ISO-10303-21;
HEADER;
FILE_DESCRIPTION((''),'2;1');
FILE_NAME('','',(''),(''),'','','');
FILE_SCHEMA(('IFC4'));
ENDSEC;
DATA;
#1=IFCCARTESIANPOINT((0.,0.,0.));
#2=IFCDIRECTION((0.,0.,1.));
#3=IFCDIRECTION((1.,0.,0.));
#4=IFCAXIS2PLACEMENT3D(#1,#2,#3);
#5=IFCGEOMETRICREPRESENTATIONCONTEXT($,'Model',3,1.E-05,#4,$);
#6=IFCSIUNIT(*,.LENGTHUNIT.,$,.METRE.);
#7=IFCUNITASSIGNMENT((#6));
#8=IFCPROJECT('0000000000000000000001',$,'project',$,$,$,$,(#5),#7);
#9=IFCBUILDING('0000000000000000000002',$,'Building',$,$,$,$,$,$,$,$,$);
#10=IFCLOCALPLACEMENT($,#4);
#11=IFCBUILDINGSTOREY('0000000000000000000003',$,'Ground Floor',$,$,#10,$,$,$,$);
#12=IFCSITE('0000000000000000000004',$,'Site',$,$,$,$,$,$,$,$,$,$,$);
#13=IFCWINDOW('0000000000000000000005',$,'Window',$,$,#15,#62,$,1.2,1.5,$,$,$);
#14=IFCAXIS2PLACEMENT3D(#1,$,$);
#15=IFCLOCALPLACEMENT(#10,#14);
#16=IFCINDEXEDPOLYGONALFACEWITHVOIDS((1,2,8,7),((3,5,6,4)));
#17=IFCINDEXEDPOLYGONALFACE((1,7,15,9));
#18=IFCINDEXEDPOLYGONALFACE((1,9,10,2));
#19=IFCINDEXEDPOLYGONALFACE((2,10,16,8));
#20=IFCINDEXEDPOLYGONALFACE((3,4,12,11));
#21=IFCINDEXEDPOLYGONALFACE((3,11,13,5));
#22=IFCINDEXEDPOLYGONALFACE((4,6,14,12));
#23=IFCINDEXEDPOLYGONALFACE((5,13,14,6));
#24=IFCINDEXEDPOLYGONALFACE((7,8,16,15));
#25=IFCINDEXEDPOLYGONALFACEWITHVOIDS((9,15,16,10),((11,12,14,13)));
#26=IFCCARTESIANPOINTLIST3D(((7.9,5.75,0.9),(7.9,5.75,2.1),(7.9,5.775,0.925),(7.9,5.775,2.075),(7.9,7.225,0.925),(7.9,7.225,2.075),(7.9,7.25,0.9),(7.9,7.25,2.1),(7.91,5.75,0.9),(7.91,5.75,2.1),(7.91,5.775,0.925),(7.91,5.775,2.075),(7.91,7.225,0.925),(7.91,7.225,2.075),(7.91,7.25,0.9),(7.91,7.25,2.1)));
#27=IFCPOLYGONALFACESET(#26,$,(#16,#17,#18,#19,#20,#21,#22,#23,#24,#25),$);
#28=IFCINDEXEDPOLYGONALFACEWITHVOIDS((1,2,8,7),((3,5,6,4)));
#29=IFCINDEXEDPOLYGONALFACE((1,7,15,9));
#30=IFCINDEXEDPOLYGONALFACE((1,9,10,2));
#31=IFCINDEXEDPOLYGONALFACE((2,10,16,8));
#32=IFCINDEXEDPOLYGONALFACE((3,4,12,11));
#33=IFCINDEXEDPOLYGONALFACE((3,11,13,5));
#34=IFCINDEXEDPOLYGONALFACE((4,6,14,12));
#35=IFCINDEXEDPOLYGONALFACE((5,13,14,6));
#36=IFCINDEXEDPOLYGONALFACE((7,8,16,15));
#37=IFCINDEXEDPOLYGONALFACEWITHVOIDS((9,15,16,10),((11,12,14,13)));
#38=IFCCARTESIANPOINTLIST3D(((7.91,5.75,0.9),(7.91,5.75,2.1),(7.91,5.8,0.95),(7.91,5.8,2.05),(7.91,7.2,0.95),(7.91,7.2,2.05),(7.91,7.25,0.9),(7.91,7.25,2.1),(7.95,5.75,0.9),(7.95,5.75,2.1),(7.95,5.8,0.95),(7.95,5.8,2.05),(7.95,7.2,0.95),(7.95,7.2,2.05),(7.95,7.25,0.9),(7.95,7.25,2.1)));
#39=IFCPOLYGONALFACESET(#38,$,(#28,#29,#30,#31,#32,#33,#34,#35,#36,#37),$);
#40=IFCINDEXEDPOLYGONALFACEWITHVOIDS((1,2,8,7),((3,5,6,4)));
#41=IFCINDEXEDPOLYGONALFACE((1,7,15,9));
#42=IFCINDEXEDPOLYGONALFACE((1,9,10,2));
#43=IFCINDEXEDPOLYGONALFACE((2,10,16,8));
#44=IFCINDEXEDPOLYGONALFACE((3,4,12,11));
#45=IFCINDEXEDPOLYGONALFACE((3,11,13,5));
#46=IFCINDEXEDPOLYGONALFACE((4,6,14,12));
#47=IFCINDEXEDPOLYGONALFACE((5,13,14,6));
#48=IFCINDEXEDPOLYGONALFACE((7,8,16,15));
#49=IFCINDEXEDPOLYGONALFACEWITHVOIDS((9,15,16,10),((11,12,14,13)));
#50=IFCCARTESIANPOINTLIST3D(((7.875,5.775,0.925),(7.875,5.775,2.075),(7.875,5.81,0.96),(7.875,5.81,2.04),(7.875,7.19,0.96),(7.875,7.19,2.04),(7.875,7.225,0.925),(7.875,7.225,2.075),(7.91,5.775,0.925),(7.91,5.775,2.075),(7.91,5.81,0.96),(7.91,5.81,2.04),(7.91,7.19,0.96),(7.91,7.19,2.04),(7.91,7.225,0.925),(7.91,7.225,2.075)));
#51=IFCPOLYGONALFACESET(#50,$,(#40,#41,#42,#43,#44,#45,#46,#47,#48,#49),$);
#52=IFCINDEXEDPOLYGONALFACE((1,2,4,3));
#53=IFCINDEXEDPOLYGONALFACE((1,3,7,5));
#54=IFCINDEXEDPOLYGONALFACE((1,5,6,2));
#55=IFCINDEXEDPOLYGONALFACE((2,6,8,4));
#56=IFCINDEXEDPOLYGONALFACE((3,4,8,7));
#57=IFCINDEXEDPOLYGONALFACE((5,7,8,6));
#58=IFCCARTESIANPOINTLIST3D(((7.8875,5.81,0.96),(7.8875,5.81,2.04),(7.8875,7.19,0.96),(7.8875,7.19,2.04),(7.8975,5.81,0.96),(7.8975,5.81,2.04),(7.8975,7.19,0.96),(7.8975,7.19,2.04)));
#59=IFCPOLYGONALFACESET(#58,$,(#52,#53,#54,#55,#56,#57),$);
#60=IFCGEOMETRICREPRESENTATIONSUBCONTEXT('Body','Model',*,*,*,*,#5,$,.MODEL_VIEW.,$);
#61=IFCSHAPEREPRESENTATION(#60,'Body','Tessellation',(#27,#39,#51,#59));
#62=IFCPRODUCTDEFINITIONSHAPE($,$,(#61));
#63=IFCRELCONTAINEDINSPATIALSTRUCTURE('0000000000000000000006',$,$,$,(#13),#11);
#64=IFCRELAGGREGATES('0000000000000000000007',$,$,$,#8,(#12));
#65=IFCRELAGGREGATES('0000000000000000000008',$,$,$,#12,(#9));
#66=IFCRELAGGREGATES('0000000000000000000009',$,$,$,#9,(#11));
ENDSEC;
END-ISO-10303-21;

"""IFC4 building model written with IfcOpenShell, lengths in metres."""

from ifc_helpers import new_model, si_unit, frame, origin_with_axes, place, context, subcontext, project, spatial, line, indexed_curve, outline, extrude, element, save


model = new_model("IFC4")

# Units and contexts
model_context = context("Model", 3, precision=1e-05, world=origin_with_axes())
body_context = subcontext(model_context, "Body", "Model", "MODEL_VIEW")
ifc_project = project(units=[si_unit("LENGTHUNIT", "METRE")], contexts=[model_context])

# Site, building, storey
site = spatial("IfcSite", under=ifc_project, Name="Site")
building = spatial("IfcBuilding", under=site, Name="Building")
storey_placement = place(None, origin_with_axes())
storey = spatial("IfcBuildingStorey", under=building, at=storey_placement, Name="Ground Floor")

# Window
for number, where, z_axis, x_axis, name in (
    (1, (8.0, 5.75, 0.9), (0.0, 0.0, 1.0), (0.0, 1.0, 0.0), "Window"),
):
    element("IfcWindow", number, at=place(storey_placement, frame(where, z_axis=z_axis, x_axis=x_axis)), inside=storey, Name=name, OverallHeight=1.2, OverallWidth=1.5, context=body_context, shape_type="SweptSolid", body=[
        extrude(outline(indexed_curve([(0.0, 0.0), (1.5, 0.0), (1.5, 1.2), (0.0, 1.2)], segments=[line(1, 2, 3, 4, 1)]), holes=[indexed_curve([(0.025, 0.025), (1.475, 0.025), (1.475, 1.175), (0.025, 1.175)], segments=[line(1, 2, 3, 4, 1)])]), frame((0.0, 0.09, 0.0), z_axis=(0.0, -1.0, 0.0), x_axis=(1.0, 0.0, 0.0)), (0.0, 0.0, -1.0), 0.01),
        extrude(outline(indexed_curve([(0.0, 0.0), (1.5, 0.0), (1.5, 1.2), (0.0, 1.2)], segments=[line(1, 2, 3, 4, 1)]), holes=[indexed_curve([(0.05, 0.05), (1.45, 0.05), (1.45, 1.15), (0.05, 1.15)], segments=[line(1, 2, 3, 4, 1)])]), frame((0.0, 0.05, 0.0), z_axis=(0.0, -1.0, 0.0), x_axis=(1.0, 0.0, 0.0)), (0.0, 0.0, -1.0), 0.04),
        extrude(outline(indexed_curve([(0.0, 0.0), (1.45, 0.0), (1.45, 1.15), (0.0, 1.15)], segments=[line(1, 2, 3, 4, 1)]), holes=[indexed_curve([(0.035, 0.035), (1.415, 0.035), (1.415, 1.115), (0.035, 1.115)], segments=[line(1, 2, 3, 4, 1)])]), frame((0.025, 0.09, 0.025), z_axis=(0.0, -1.0, 0.0), x_axis=(1.0, 0.0, 0.0)), (0.0, 0.0, -1.0), 0.035),
        extrude(outline(indexed_curve([(0.035, 0.035), (1.415, 0.035), (1.415, 1.115), (0.035, 1.115)], segments=[line(1, 2, 3, 4, 1)])), frame((0.025, 0.1025, 0.025), z_axis=(0.0, -1.0, 0.0), x_axis=(1.0, 0.0, 0.0)), (0.0, 0.0, -1.0), 0.01),
    ])

save(model, "model.ifc")
